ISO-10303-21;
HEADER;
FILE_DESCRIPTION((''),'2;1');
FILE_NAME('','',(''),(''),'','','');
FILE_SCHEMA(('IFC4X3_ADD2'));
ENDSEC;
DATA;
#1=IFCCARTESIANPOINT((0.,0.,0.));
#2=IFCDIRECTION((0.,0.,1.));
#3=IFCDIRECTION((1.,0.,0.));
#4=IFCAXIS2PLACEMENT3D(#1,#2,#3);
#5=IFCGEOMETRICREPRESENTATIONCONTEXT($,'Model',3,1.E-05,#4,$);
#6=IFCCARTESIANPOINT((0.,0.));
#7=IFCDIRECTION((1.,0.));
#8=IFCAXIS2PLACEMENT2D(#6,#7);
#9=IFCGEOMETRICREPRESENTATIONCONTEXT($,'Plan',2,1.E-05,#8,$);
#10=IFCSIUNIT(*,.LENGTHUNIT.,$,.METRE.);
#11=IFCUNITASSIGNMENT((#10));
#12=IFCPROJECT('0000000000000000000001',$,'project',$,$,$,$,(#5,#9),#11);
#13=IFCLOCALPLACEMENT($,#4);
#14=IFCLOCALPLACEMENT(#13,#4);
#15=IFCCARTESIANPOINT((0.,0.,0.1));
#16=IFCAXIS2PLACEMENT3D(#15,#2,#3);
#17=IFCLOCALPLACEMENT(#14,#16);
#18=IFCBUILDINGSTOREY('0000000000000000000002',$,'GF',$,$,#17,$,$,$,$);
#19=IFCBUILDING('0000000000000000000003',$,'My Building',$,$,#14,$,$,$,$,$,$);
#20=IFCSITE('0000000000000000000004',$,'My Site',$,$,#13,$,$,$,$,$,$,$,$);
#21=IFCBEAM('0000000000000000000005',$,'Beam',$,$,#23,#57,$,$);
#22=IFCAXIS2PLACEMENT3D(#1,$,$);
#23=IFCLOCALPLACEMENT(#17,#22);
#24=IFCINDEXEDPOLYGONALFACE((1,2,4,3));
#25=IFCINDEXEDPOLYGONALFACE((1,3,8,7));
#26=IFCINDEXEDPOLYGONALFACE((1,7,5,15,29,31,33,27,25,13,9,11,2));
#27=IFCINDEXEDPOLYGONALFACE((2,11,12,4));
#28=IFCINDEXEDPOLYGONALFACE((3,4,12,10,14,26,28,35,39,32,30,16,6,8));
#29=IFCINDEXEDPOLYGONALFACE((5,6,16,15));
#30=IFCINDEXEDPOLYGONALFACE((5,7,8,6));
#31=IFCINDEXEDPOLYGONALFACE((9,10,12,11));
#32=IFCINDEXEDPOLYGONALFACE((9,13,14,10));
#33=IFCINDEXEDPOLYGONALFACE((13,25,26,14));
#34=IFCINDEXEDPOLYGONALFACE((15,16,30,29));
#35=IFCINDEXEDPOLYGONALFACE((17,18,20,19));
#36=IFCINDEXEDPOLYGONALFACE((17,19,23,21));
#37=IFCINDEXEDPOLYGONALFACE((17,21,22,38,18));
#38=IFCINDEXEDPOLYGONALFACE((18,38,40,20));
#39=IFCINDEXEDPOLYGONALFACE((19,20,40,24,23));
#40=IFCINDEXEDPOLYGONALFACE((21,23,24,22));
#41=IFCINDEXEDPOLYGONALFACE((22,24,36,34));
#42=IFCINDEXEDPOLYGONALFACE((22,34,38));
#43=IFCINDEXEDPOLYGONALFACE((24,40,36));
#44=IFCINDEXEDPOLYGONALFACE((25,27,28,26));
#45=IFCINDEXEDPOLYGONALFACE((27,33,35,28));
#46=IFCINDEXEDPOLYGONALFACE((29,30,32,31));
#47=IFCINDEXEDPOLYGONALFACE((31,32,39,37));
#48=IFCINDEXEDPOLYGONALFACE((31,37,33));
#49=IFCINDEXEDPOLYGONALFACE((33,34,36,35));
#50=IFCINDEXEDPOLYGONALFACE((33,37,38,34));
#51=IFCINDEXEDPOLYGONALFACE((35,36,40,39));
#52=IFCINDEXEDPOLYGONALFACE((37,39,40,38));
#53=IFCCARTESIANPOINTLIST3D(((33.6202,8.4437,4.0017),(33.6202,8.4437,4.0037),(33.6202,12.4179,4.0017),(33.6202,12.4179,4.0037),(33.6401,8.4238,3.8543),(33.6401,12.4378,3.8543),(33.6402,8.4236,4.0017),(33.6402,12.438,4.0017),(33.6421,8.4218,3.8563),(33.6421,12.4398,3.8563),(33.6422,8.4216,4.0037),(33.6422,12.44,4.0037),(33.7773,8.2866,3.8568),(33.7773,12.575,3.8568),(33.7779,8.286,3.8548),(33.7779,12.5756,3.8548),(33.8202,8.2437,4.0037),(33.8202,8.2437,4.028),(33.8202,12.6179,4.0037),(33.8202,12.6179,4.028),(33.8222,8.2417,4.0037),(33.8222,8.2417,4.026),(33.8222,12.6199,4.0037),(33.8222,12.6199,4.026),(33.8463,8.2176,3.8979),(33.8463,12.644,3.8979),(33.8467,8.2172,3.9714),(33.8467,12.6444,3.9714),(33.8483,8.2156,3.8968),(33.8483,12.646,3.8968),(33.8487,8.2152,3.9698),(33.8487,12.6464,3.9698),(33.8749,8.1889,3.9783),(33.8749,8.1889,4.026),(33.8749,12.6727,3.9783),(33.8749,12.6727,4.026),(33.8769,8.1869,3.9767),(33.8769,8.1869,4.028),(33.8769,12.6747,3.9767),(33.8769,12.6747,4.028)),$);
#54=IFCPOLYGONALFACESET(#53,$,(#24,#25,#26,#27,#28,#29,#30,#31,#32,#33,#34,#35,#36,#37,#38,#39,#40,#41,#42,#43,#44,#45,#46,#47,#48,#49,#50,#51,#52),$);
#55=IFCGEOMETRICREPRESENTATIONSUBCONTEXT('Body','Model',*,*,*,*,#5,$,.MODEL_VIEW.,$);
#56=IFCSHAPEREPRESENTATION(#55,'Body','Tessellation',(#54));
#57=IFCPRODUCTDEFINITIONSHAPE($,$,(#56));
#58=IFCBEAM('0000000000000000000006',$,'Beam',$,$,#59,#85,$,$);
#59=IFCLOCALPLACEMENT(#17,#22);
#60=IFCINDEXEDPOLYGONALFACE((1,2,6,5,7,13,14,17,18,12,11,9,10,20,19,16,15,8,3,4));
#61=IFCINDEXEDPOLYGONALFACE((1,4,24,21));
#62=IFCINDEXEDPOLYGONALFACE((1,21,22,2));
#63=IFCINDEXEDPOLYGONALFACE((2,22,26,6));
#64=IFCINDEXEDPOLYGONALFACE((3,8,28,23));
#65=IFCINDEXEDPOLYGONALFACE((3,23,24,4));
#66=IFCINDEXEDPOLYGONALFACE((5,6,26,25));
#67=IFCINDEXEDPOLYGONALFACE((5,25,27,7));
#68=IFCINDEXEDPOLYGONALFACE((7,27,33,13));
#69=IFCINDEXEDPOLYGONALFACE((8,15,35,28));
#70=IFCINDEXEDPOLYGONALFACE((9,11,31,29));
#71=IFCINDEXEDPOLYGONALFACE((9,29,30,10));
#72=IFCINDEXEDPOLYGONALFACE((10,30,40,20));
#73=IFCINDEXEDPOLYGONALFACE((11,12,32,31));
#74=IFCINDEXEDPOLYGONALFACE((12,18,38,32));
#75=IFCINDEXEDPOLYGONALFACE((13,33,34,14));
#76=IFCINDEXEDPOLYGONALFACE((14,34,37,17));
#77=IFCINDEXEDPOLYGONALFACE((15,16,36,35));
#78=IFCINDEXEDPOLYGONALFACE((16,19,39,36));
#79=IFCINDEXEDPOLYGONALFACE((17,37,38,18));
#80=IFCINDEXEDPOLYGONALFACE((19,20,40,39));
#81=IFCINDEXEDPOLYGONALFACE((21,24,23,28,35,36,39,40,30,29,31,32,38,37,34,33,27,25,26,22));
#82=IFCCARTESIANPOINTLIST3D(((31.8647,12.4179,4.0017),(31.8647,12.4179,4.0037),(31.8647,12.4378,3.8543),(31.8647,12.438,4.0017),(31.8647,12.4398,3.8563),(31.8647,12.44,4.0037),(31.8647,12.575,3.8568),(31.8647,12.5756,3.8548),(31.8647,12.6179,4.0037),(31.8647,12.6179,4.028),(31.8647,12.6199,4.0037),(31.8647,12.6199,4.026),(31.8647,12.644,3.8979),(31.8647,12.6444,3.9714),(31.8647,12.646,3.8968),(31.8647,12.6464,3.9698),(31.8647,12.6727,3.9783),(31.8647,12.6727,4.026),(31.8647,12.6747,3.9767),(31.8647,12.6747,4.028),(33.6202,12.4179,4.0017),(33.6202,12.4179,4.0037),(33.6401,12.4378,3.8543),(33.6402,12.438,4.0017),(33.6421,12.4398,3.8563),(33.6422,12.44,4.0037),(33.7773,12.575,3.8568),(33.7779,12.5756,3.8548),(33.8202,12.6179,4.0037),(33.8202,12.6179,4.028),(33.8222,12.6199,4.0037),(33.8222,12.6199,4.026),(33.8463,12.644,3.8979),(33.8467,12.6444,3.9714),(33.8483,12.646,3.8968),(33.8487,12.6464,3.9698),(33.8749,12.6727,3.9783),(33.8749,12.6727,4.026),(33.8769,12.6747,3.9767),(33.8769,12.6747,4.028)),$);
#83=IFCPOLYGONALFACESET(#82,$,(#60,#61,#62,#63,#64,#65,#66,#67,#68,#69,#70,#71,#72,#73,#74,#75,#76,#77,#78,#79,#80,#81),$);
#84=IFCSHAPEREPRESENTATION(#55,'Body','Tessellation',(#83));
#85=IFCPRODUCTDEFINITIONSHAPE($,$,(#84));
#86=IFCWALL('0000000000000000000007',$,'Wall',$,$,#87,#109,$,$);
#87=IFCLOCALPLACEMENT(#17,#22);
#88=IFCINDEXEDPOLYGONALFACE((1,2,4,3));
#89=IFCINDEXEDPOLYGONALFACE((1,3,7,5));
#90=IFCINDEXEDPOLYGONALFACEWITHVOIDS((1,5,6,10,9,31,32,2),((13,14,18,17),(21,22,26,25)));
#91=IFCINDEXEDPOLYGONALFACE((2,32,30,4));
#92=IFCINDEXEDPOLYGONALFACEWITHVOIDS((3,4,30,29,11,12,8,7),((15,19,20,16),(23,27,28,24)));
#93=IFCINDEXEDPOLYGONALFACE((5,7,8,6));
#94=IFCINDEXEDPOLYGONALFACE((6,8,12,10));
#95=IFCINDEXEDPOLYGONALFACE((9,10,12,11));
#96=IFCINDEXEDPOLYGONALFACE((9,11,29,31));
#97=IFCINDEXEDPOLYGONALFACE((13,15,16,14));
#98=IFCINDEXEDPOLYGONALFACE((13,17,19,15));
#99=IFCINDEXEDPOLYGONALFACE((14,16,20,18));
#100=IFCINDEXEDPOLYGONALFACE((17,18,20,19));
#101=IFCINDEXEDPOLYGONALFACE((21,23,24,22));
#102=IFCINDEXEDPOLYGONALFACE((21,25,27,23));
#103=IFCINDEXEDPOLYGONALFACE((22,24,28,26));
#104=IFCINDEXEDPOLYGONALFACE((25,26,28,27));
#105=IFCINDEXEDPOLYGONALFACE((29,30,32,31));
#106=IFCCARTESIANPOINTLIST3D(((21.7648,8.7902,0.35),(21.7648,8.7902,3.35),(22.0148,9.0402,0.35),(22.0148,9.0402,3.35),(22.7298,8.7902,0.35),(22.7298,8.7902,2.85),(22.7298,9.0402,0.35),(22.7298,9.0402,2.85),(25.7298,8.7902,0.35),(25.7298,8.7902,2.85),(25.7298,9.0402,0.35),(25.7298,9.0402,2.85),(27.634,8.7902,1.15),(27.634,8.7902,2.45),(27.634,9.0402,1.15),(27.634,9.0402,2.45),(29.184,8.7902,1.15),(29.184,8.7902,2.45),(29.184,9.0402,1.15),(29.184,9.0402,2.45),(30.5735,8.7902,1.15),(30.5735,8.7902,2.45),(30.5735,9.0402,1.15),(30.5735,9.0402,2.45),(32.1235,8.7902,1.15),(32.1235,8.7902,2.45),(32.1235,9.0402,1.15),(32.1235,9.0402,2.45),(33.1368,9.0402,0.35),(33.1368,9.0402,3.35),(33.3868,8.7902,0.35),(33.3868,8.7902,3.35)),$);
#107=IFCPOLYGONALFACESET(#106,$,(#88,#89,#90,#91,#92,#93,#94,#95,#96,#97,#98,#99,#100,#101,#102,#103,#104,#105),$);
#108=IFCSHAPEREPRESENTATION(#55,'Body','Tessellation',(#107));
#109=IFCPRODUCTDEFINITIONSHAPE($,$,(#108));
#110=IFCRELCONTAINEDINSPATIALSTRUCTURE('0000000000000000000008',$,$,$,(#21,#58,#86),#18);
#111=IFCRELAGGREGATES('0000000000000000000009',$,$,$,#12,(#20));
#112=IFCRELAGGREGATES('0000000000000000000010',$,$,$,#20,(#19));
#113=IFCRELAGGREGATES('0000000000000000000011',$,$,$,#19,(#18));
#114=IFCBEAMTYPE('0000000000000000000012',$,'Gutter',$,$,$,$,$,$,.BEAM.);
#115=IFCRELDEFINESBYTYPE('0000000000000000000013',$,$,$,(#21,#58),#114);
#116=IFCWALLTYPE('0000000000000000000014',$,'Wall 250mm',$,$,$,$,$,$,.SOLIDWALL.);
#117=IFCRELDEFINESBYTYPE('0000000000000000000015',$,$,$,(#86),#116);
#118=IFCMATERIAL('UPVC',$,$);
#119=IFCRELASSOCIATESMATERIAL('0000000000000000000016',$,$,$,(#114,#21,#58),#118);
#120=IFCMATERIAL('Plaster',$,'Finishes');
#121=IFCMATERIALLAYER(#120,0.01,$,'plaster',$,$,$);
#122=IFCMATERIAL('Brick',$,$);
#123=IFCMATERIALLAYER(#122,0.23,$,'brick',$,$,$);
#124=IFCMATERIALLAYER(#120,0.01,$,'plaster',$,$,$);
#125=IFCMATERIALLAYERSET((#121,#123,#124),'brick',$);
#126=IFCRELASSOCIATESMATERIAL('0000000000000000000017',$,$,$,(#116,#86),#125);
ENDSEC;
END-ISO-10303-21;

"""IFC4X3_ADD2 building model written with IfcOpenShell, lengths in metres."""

from ifc_helpers import new_model, si_unit, frame, origin_with_axes, origin_2d_with_axis, place, context, subcontext, project, spatial, line, indexed_curve, outline, extrude, clip, halfspace, source, transform, mapped, material, layer, layer_set, layer_usage, material_profile, profile_set, profile_usage, type_object, element, save


model = new_model("IFC4X3_ADD2")

# Units and contexts
model_context = context("Model", 3, precision=1e-05, world=origin_with_axes())
plan_context = context("Plan", 2, precision=1e-05, world=origin_2d_with_axis())
body_context_1 = subcontext(model_context, "Body", "Model", "MODEL_VIEW")
ifc_project = project(units=[si_unit("LENGTHUNIT", "METRE")], contexts=[model_context, plan_context])

# Site, building, storey
site_placement = place(None, origin_with_axes())
site = spatial("IfcSite", under=ifc_project, at=site_placement, Name="My Site")
building_placement = place(site_placement, origin_with_axes())
building = spatial("IfcBuilding", under=site, at=building_placement, Name="My Building")
storey_placement = place(building_placement, frame((0.0, 0.0, 0.1), z_axis=(0.0, 0.0, 1.0), x_axis=(1.0, 0.0, 0.0)))
storey = spatial("IfcBuildingStorey", under=building, at=storey_placement, Name="GF")

# Beams
ifc_material_1 = material(Name="UPVC")
ifc_material_profile_1 = material_profile(ifc_material_1, outline(indexed_curve([(0.0548, 0.1717), (0.002, 0.1717), (0.002, 0.124), (0.0303, 0.1171), (0.0307, 0.0436), (0.0996, 0.0025), (0.2349, 0.002), (0.2347, 0.1494), (0.2567, 0.1494), (0.2567, 0.1474), (0.2367, 0.1474), (0.2369, 0.0), (0.0991, 0.0005), (0.0287, 0.0425), (0.0283, 0.1155), (0.0, 0.1224), (0.0, 0.1737), (0.0568, 0.1737), (0.0568, 0.1494), (0.0548, 0.1494), (0.0548, 0.1717)])))
ifc_profile_set_1 = profile_set([ifc_material_profile_1])
ifc_profile_usage_1 = profile_usage(ifc_profile_set_1)
beam_type = type_object("IfcBeamType", Name="Gutter", PredefinedType="BEAM", material=ifc_profile_set_1)
beam_1_placement = place(storey_placement, frame((33.8769, 8.1869, 3.8543), z_axis=(0.0, 1.0, 0.0), x_axis=(-1.0, 0.0, 0.0)))
element("IfcBeam", 1, at=beam_1_placement, inside=storey, type_object=beam_type, material=ifc_profile_usage_1, Name="Beam", context=body_context_1, shape_type="Clipping", body=[
    clip(clip(extrude(outline(indexed_curve([(0.0548, 0.1717), (0.002, 0.1717), (0.002, 0.124), (0.0303, 0.1171), (0.0307, 0.0436), (0.0996, 0.0025), (0.2349, 0.002), (0.2347, 0.1494), (0.2567, 0.1494), (0.2567, 0.1474), (0.2367, 0.1474), (0.2369, 0.0), (0.0991, 0.0005), (0.0287, 0.0425), (0.0283, 0.1155), (0.0, 0.1224), (0.0, 0.1737), (0.0568, 0.1737), (0.0568, 0.1494), (0.0548, 0.1494), (0.0548, 0.1717)])), origin_with_axes(), (0.0, 0.0, 1.0), 4.4877), halfspace(frame((0.0, -3.9543, 4.4877), z_axis=(0.707104, 0.0, 0.707109), x_axis=(0.0, -1.0, 0.0)), False)), halfspace(frame((0.0, -3.9543, 0.0), z_axis=(0.707104, 0.0, -0.70711), x_axis=(0.0, -1.0, 0.0)), False)),
])
ifc_profile_usage_2 = profile_usage(ifc_profile_set_1)
beam_2_placement = place(storey_placement, frame((33.8769, 12.6747, 3.8543), z_axis=(-1.0, 0.000001, 0.0), x_axis=(-0.000001, -1.0, 0.0)))
element("IfcBeam", 2, at=beam_2_placement, inside=storey, type_object=beam_type, material=ifc_profile_usage_2, Name="Beam", context=body_context_1, shape_type="Clipping", body=[
    clip(extrude(outline(indexed_curve([(0.0548, 0.1717), (0.002, 0.1717), (0.002, 0.124), (0.0303, 0.1171), (0.0307, 0.0436), (0.0996, 0.0025), (0.2349, 0.002), (0.2347, 0.1494), (0.2567, 0.1494), (0.2567, 0.1474), (0.2367, 0.1474), (0.2369, 0.0), (0.0991, 0.0005), (0.0287, 0.0425), (0.0283, 0.1155), (0.0, 0.1224), (0.0, 0.1737), (0.0568, 0.1737), (0.0568, 0.1494), (0.0548, 0.1494), (0.0548, 0.1717)])), origin_with_axes(), (0.0, 0.0, 1.0), 2.0122), halfspace(frame((0.0, -3.9543, 0.0), z_axis=(0.707109, 0.0, -0.707105), x_axis=(0.0, -1.0, 0.0)), False)),
])

# Shared definitions
ifc_material_2 = material(Name="Plaster", Category="Finishes")
ifc_layer_1 = layer(ifc_material_2, 0.01, Name="plaster")
ifc_material_3 = material(Name="Brick")
ifc_layer_2 = layer(ifc_material_3, 0.23, Name="brick")
ifc_layer_3 = layer(ifc_material_2, 0.01, Name="plaster")
ifc_layer_set_1 = layer_set([ifc_layer_1, ifc_layer_2, ifc_layer_3], Name="brick")
wall_type_1 = type_object("IfcWallType", Name="Wall 250mm", PredefinedType="SOLIDWALL", material=ifc_layer_set_1)

# Wall, openings
ifc_layer_usage_1 = layer_usage(ifc_layer_set_1, "AXIS2", "NEGATIVE", 0.0)
wall_1_placement = place(storey_placement, frame((33.3868, 8.7902, 0.35), z_axis=(0.0, 0.0, 1.0), x_axis=(-1.0, 0.0, 0.0)))
wall_1 = element("IfcWall", 3, at=wall_1_placement, inside=storey, type_object=wall_type_1, material=ifc_layer_usage_1, Name="Wall", context=body_context_1, shape_type="SweptSolid", body=[
    extrude(outline(indexed_curve([(0.25, -0.25), (0.0, 0.0), (11.622, 0.0), (11.372, -0.25)], segments=[line(1, 2, 3, 4, 1)])), origin_with_axes(), (0.0, 0.0, 1.0), 3.0),
])
shared_shape_1 = source(origin_with_axes(), body_context_1, "Body", "SweptSolid", [
    extrude(outline(indexed_curve([(0.0, 0.0), (3.0, 0.0), (3.0, 2.5), (0.0, 2.5)], segments=[line(1, 2, 3, 4, 1)])), frame((0.0, -0.6, 0.0), z_axis=(0.0, -1.0, 0.0), x_axis=(1.0, 0.0, 0.0)), (0.0, 0.0, -1.0), 1.2),
])
opening_1_placement = place(wall_1_placement, frame((7.657, 0.0, 0.0), z_axis=(0.0, 0.0, 1.0), x_axis=(1.0, 0.0, 0.0)))
element("IfcOpeningElement", 4, at=opening_1_placement, cuts=wall_1, PredefinedType="OPENING", context=body_context_1, shape_type="MappedRepresentation", body=[
    mapped(shared_shape_1, transform((0.0, 0.0, 0.0), x_axis=(1.0, 0.0, 0.0), y_axis=(0.0, 1.0, 0.0), z_axis=(0.0, 0.0, 1.0), scale=1.0)),
])
shared_shape_2 = source(origin_with_axes(), body_context_1, "Body", "SweptSolid", [
    extrude(outline(indexed_curve([(0.0, 0.0), (1.55, 0.0), (1.55, 1.3), (0.0, 1.3)], segments=[line(1, 2, 3, 4, 1)])), frame((-0.775, -0.6, 0.0), z_axis=(0.0, -1.0, 0.0), x_axis=(1.0, 0.0, 0.0)), (0.0, 0.0, -1.0), 1.2),
])
opening_2_placement = place(wall_1_placement, frame((2.0383, -0.23, 0.8), z_axis=(0.0, 0.0, 1.0), x_axis=(1.0, 0.0, 0.0)))
element("IfcOpeningElement", 5, at=opening_2_placement, cuts=wall_1, PredefinedType="OPENING", context=body_context_1, shape_type="MappedRepresentation", body=[
    mapped(shared_shape_2, transform((0.0, 0.0, 0.0), x_axis=(1.0, 0.0, 0.0), y_axis=(0.0, 1.0, 0.0), z_axis=(0.0, 0.0, 1.0), scale=1.0)),
])
opening_3_placement = place(wall_1_placement, frame((4.9778, 0.0, 0.8), z_axis=(0.0, 0.0, 1.0), x_axis=(1.0, 0.0, 0.0)))
element("IfcOpeningElement", 6, at=opening_3_placement, cuts=wall_1, PredefinedType="OPENING", context=body_context_1, shape_type="MappedRepresentation", body=[
    mapped(shared_shape_2, transform((0.0, 0.0, 0.0), x_axis=(1.0, 0.0, 0.0), y_axis=(0.0, 1.0, 0.0), z_axis=(0.0, 0.0, 1.0), scale=1.0)),
])

save(model, "model.ifc")
